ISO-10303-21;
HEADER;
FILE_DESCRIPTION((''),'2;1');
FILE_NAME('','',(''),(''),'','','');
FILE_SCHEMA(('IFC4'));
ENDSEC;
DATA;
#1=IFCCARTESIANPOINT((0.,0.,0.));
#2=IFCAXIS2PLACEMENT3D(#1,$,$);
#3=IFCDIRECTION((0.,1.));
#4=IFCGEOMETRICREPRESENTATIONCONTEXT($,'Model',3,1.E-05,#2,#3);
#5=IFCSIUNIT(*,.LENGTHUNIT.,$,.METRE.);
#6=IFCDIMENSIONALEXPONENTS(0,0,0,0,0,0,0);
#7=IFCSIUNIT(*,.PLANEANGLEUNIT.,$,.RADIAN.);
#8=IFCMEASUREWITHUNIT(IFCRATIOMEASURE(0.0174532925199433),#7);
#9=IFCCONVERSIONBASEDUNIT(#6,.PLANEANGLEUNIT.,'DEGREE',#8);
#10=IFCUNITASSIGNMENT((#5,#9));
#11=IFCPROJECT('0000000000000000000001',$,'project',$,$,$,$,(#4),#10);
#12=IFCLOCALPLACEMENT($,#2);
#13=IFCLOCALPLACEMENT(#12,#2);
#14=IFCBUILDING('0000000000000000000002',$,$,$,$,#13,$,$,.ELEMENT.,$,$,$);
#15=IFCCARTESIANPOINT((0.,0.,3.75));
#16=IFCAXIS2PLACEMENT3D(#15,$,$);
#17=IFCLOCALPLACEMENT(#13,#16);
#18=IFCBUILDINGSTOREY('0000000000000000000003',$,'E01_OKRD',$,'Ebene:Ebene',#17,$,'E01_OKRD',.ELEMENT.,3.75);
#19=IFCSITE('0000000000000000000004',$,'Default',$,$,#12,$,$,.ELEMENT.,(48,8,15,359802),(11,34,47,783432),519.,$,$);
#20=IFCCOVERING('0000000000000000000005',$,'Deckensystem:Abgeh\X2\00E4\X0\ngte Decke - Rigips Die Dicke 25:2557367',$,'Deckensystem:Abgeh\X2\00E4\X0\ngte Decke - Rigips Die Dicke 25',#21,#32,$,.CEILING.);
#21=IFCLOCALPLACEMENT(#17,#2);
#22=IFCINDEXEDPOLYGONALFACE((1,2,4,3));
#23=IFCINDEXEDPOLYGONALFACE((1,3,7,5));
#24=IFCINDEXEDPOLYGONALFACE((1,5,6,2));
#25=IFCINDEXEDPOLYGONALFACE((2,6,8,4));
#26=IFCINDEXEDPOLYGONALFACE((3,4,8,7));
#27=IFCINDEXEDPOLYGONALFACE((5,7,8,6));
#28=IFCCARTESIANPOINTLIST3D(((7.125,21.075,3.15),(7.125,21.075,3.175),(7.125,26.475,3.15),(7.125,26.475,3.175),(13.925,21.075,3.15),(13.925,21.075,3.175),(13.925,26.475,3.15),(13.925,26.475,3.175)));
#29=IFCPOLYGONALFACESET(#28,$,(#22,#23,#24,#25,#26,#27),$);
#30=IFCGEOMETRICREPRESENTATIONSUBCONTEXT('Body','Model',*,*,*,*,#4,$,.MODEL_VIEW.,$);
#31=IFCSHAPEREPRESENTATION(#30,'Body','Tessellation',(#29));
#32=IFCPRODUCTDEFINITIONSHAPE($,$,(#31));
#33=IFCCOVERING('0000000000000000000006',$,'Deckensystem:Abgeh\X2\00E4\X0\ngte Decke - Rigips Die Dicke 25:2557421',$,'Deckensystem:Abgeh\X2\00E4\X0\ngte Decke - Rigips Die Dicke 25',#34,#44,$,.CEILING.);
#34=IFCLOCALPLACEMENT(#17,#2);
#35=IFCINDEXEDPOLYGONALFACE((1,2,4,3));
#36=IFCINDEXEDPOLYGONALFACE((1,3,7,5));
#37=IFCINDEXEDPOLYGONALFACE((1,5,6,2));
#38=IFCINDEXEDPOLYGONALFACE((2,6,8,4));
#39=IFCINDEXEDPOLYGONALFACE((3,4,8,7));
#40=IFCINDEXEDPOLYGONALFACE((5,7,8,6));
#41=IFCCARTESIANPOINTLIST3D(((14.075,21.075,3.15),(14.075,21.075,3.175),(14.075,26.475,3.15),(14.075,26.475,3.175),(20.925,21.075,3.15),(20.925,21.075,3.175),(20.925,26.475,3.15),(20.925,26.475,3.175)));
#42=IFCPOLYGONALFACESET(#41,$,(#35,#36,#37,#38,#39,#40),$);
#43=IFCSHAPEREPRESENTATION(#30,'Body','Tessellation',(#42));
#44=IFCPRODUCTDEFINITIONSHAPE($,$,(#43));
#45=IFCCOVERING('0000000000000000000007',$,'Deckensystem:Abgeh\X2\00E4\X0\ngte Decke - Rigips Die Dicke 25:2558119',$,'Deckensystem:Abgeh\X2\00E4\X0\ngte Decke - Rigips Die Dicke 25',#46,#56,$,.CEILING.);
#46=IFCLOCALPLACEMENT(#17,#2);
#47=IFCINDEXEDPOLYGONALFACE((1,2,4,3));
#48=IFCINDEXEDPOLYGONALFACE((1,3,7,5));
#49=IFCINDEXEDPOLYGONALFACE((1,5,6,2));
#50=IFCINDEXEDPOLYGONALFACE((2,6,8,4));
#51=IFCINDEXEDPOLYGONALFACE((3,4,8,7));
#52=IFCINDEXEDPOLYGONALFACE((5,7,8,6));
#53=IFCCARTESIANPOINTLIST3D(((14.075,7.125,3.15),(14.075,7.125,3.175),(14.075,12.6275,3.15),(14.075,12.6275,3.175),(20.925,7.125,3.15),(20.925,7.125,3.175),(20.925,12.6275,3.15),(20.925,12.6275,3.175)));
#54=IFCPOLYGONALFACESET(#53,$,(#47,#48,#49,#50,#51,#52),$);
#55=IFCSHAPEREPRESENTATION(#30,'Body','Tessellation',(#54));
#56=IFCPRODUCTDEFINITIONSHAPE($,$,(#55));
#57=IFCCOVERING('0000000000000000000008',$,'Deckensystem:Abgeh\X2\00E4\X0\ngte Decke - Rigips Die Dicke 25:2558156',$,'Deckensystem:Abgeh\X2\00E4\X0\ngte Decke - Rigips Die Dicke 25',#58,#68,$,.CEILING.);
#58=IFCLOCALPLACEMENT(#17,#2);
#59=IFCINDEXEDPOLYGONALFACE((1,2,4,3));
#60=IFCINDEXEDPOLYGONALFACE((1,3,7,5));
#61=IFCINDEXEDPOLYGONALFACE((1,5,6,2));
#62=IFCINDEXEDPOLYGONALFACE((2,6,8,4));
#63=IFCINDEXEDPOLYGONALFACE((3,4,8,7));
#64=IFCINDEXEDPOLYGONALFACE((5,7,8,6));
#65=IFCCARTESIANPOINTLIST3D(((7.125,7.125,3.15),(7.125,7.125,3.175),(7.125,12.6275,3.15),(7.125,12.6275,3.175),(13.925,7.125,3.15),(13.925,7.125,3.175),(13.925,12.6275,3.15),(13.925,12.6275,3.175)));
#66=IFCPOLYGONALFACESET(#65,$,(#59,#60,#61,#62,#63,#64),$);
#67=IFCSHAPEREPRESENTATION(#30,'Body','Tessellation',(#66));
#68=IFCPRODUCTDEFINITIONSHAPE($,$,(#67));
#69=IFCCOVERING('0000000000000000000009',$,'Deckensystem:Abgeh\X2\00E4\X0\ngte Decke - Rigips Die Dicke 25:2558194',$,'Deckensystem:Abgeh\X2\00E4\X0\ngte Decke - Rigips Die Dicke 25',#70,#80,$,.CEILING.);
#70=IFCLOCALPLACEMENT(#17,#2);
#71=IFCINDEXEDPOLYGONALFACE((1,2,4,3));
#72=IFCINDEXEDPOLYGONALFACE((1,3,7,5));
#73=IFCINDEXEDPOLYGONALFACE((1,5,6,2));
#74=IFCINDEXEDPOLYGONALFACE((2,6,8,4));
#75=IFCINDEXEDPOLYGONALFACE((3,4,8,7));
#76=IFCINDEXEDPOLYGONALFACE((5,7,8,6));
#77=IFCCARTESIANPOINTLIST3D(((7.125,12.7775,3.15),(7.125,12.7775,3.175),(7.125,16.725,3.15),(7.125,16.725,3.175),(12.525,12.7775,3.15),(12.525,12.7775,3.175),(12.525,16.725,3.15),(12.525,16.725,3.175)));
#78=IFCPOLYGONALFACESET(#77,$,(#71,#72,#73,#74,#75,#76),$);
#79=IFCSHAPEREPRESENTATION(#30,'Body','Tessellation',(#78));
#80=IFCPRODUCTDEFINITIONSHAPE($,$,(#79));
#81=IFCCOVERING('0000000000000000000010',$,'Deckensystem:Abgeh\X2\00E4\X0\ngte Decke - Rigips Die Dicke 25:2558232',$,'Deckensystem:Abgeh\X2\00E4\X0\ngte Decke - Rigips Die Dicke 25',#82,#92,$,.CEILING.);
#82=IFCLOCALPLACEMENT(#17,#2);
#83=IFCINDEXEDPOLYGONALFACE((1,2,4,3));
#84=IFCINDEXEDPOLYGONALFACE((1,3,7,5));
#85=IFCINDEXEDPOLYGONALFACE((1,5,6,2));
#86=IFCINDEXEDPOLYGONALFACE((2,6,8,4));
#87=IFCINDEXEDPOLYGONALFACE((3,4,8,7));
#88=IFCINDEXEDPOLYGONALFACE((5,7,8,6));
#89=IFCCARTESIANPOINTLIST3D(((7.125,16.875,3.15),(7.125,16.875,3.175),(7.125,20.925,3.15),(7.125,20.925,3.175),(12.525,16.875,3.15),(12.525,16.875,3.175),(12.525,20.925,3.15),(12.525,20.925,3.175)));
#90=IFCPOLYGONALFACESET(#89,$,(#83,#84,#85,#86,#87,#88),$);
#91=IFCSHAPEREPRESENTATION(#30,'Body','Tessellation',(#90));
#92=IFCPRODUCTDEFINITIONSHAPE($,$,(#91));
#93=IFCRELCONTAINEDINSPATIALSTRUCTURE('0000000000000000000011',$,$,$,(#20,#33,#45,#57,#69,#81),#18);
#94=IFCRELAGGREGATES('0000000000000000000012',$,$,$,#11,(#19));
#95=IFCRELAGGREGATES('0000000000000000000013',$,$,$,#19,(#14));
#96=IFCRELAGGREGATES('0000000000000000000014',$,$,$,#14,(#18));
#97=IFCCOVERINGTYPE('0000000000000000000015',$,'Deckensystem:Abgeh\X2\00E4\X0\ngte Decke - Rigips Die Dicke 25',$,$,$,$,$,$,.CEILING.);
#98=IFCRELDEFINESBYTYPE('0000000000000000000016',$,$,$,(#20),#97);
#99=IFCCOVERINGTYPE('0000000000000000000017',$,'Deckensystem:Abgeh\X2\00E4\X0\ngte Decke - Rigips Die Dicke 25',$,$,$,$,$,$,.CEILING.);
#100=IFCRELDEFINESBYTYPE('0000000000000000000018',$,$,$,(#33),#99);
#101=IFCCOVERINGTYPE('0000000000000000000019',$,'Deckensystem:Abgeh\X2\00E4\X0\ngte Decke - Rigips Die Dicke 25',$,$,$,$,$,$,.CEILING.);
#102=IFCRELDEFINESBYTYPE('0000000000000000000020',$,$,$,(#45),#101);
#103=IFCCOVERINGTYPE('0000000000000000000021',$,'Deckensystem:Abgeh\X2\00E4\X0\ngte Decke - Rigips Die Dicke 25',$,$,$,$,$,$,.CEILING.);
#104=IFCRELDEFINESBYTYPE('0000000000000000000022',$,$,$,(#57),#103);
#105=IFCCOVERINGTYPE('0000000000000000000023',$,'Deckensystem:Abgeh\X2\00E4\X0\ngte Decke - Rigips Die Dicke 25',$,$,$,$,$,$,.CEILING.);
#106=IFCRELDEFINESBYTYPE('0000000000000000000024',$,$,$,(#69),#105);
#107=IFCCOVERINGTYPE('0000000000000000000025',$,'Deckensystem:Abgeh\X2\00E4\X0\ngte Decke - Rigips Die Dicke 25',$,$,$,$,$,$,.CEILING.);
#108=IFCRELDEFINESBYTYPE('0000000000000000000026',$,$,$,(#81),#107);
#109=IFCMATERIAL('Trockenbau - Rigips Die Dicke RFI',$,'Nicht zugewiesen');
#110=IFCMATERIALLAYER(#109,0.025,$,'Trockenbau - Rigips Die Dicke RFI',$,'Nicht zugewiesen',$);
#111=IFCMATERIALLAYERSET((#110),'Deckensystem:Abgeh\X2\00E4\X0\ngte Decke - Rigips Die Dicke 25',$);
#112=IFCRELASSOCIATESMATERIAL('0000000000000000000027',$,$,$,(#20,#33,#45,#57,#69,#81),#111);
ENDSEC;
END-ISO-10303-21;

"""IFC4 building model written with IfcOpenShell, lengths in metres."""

from ifc_helpers import new_model, entity, si_unit, converted_unit, direction, frame, frame_2d, origin, origin_2d_with_axis, place, context, subcontext, project, spatial, rectangle, extrude, material, layer, layer_set, layer_usage, type_object, element, save


model = new_model("IFC4")

# Units and contexts
model_context = context("Model", 3, precision=1e-05, world=origin(), true_north=direction((0.0, 1.0)))
body_context = subcontext(model_context, "Body", "Model", "MODEL_VIEW")
ifc_project = project(units=[si_unit("LENGTHUNIT", "METRE"), converted_unit("PLANEANGLEUNIT", "DEGREE", entity("IfcRatioMeasure", 0.0174532925199433), si_unit("PLANEANGLEUNIT", "RADIAN"), dimensions=[0, 0, 0, 0, 0, 0, 0])], contexts=[model_context])

# Site, building, storey
site_placement = place(None, frame((0.0, 0.0, 0.0)))
site = spatial("IfcSite", under=ifc_project, at=site_placement, Name="Default", CompositionType="ELEMENT", RefLatitude=(48, 8, 15, 359802), RefLongitude=(11, 34, 47, 783432), RefElevation=519.0)
building_placement = place(site_placement, origin())
building = spatial("IfcBuilding", under=site, at=building_placement, CompositionType="ELEMENT")
storey_placement = place(building_placement, frame((0.0, 0.0, 3.75)))
storey = spatial("IfcBuildingStorey", under=building, at=storey_placement, Name="E01_OKRD", ObjectType="Ebene:Ebene", LongName="E01_OKRD", CompositionType="ELEMENT", Elevation=3.75)

# Coverings
ifc_material_1 = material(Name="Trockenbau - Rigips Die Dicke RFI", Category="Nicht zugewiesen")
ifc_layer_1 = layer(ifc_material_1, 0.025, Name="Trockenbau - Rigips Die Dicke RFI", Category="Nicht zugewiesen")
ifc_layer_set_1 = layer_set([ifc_layer_1], Name="Deckensystem:Abgehängte Decke - Rigips Die Dicke 25")
ifc_layer_usage_1 = layer_usage(ifc_layer_set_1, "AXIS3", "POSITIVE", 0.0)
covering_type_1 = type_object("IfcCoveringType", Name="Deckensystem:Abgehängte Decke - Rigips Die Dicke 25", PredefinedType="CEILING")
covering_1_placement = place(storey_placement, frame((7.125, 21.075, 3.15)))
element("IfcCovering", 1, at=covering_1_placement, inside=storey, type_object=covering_type_1, material=ifc_layer_usage_1, Name="Deckensystem:Abgehängte Decke - Rigips Die Dicke 25:2557367", ObjectType="Deckensystem:Abgehängte Decke - Rigips Die Dicke 25", PredefinedType="CEILING", context=body_context, shape_type="SweptSolid", body=[
    extrude(rectangle(XDim=6.8, YDim=5.4, at=frame_2d((0.0, 0.0), x_axis=(1.0, 0.0))), frame((3.4, 2.7, 0.0), z_axis=(0.0, 0.0, 1.0), x_axis=(-1.0, 0.0, 0.0)), (0.0, 0.0, 1.0), 0.025),
])
ifc_layer_usage_2 = layer_usage(ifc_layer_set_1, "AXIS3", "POSITIVE", 0.0)
covering_type_2 = type_object("IfcCoveringType", Name="Deckensystem:Abgehängte Decke - Rigips Die Dicke 25", PredefinedType="CEILING")
covering_2_placement = place(storey_placement, frame((14.075, 21.075, 3.15)))
element("IfcCovering", 2, at=covering_2_placement, inside=storey, type_object=covering_type_2, material=ifc_layer_usage_2, Name="Deckensystem:Abgehängte Decke - Rigips Die Dicke 25:2557421", ObjectType="Deckensystem:Abgehängte Decke - Rigips Die Dicke 25", PredefinedType="CEILING", context=body_context, shape_type="SweptSolid", body=[
    extrude(rectangle(XDim=6.85, YDim=5.4, at=frame_2d((0.0, 0.0), x_axis=(1.0, 0.0))), frame((3.425, 2.7, 0.0), z_axis=(0.0, 0.0, 1.0), x_axis=(-1.0, 0.0, 0.0)), (0.0, 0.0, 1.0), 0.025),
])
ifc_layer_usage_3 = layer_usage(ifc_layer_set_1, "AXIS3", "POSITIVE", 0.0)
covering_type_3 = type_object("IfcCoveringType", Name="Deckensystem:Abgehängte Decke - Rigips Die Dicke 25", PredefinedType="CEILING")
covering_3_placement = place(storey_placement, frame((14.075, 7.125, 3.15)))
element("IfcCovering", 3, at=covering_3_placement, inside=storey, type_object=covering_type_3, material=ifc_layer_usage_3, Name="Deckensystem:Abgehängte Decke - Rigips Die Dicke 25:2558119", ObjectType="Deckensystem:Abgehängte Decke - Rigips Die Dicke 25", PredefinedType="CEILING", context=body_context, shape_type="SweptSolid", body=[
    extrude(rectangle(XDim=5.5025, YDim=6.85, at=origin_2d_with_axis()), frame((3.425, 2.7512, 0.0), z_axis=(0.0, 0.0, 1.0), x_axis=(0.0, -1.0, 0.0)), (0.0, 0.0, 1.0), 0.025),
])
ifc_layer_usage_4 = layer_usage(ifc_layer_set_1, "AXIS3", "POSITIVE", 0.0)
covering_type_4 = type_object("IfcCoveringType", Name="Deckensystem:Abgehängte Decke - Rigips Die Dicke 25", PredefinedType="CEILING")
covering_4_placement = place(storey_placement, frame((7.125, 7.125, 3.15)))
element("IfcCovering", 4, at=covering_4_placement, inside=storey, type_object=covering_type_4, material=ifc_layer_usage_4, Name="Deckensystem:Abgehängte Decke - Rigips Die Dicke 25:2558156", ObjectType="Deckensystem:Abgehängte Decke - Rigips Die Dicke 25", PredefinedType="CEILING", context=body_context, shape_type="SweptSolid", body=[
    extrude(rectangle(XDim=6.8, YDim=5.5025, at=frame_2d((0.0, 0.0), x_axis=(1.0, 0.0))), frame((3.4, 2.7512, 0.0), z_axis=(0.0, 0.0, 1.0), x_axis=(-1.0, 0.0, 0.0)), (0.0, 0.0, 1.0), 0.025),
])
ifc_layer_usage_5 = layer_usage(ifc_layer_set_1, "AXIS3", "POSITIVE", 0.0)
covering_type_5 = type_object("IfcCoveringType", Name="Deckensystem:Abgehängte Decke - Rigips Die Dicke 25", PredefinedType="CEILING")
covering_5_placement = place(storey_placement, frame((7.125, 12.7775, 3.15)))
element("IfcCovering", 5, at=covering_5_placement, inside=storey, type_object=covering_type_5, material=ifc_layer_usage_5, Name="Deckensystem:Abgehängte Decke - Rigips Die Dicke 25:2558194", ObjectType="Deckensystem:Abgehängte Decke - Rigips Die Dicke 25", PredefinedType="CEILING", context=body_context, shape_type="SweptSolid", body=[
    extrude(rectangle(XDim=5.4, YDim=3.9475, at=frame_2d((0.0, 0.0), x_axis=(1.0, 0.0))), frame((2.7, 1.9738, 0.0)), (0.0, 0.0, 1.0), 0.025),
])
ifc_layer_usage_6 = layer_usage(ifc_layer_set_1, "AXIS3", "POSITIVE", 0.0)
covering_type_6 = type_object("IfcCoveringType", Name="Deckensystem:Abgehängte Decke - Rigips Die Dicke 25", PredefinedType="CEILING")
covering_6_placement = place(storey_placement, frame((7.125, 16.875, 3.15)))
element("IfcCovering", 6, at=covering_6_placement, inside=storey, type_object=covering_type_6, material=ifc_layer_usage_6, Name="Deckensystem:Abgehängte Decke - Rigips Die Dicke 25:2558232", ObjectType="Deckensystem:Abgehängte Decke - Rigips Die Dicke 25", PredefinedType="CEILING", context=body_context, shape_type="SweptSolid", body=[
    extrude(rectangle(XDim=5.4, YDim=4.05, at=frame_2d((0.0, 0.0), x_axis=(1.0, 0.0))), frame((2.7, 2.025, 0.0), z_axis=(0.0, 0.0, 1.0), x_axis=(-1.0, 0.0, 0.0)), (0.0, 0.0, 1.0), 0.025),
])

save(model, "model.ifc")
